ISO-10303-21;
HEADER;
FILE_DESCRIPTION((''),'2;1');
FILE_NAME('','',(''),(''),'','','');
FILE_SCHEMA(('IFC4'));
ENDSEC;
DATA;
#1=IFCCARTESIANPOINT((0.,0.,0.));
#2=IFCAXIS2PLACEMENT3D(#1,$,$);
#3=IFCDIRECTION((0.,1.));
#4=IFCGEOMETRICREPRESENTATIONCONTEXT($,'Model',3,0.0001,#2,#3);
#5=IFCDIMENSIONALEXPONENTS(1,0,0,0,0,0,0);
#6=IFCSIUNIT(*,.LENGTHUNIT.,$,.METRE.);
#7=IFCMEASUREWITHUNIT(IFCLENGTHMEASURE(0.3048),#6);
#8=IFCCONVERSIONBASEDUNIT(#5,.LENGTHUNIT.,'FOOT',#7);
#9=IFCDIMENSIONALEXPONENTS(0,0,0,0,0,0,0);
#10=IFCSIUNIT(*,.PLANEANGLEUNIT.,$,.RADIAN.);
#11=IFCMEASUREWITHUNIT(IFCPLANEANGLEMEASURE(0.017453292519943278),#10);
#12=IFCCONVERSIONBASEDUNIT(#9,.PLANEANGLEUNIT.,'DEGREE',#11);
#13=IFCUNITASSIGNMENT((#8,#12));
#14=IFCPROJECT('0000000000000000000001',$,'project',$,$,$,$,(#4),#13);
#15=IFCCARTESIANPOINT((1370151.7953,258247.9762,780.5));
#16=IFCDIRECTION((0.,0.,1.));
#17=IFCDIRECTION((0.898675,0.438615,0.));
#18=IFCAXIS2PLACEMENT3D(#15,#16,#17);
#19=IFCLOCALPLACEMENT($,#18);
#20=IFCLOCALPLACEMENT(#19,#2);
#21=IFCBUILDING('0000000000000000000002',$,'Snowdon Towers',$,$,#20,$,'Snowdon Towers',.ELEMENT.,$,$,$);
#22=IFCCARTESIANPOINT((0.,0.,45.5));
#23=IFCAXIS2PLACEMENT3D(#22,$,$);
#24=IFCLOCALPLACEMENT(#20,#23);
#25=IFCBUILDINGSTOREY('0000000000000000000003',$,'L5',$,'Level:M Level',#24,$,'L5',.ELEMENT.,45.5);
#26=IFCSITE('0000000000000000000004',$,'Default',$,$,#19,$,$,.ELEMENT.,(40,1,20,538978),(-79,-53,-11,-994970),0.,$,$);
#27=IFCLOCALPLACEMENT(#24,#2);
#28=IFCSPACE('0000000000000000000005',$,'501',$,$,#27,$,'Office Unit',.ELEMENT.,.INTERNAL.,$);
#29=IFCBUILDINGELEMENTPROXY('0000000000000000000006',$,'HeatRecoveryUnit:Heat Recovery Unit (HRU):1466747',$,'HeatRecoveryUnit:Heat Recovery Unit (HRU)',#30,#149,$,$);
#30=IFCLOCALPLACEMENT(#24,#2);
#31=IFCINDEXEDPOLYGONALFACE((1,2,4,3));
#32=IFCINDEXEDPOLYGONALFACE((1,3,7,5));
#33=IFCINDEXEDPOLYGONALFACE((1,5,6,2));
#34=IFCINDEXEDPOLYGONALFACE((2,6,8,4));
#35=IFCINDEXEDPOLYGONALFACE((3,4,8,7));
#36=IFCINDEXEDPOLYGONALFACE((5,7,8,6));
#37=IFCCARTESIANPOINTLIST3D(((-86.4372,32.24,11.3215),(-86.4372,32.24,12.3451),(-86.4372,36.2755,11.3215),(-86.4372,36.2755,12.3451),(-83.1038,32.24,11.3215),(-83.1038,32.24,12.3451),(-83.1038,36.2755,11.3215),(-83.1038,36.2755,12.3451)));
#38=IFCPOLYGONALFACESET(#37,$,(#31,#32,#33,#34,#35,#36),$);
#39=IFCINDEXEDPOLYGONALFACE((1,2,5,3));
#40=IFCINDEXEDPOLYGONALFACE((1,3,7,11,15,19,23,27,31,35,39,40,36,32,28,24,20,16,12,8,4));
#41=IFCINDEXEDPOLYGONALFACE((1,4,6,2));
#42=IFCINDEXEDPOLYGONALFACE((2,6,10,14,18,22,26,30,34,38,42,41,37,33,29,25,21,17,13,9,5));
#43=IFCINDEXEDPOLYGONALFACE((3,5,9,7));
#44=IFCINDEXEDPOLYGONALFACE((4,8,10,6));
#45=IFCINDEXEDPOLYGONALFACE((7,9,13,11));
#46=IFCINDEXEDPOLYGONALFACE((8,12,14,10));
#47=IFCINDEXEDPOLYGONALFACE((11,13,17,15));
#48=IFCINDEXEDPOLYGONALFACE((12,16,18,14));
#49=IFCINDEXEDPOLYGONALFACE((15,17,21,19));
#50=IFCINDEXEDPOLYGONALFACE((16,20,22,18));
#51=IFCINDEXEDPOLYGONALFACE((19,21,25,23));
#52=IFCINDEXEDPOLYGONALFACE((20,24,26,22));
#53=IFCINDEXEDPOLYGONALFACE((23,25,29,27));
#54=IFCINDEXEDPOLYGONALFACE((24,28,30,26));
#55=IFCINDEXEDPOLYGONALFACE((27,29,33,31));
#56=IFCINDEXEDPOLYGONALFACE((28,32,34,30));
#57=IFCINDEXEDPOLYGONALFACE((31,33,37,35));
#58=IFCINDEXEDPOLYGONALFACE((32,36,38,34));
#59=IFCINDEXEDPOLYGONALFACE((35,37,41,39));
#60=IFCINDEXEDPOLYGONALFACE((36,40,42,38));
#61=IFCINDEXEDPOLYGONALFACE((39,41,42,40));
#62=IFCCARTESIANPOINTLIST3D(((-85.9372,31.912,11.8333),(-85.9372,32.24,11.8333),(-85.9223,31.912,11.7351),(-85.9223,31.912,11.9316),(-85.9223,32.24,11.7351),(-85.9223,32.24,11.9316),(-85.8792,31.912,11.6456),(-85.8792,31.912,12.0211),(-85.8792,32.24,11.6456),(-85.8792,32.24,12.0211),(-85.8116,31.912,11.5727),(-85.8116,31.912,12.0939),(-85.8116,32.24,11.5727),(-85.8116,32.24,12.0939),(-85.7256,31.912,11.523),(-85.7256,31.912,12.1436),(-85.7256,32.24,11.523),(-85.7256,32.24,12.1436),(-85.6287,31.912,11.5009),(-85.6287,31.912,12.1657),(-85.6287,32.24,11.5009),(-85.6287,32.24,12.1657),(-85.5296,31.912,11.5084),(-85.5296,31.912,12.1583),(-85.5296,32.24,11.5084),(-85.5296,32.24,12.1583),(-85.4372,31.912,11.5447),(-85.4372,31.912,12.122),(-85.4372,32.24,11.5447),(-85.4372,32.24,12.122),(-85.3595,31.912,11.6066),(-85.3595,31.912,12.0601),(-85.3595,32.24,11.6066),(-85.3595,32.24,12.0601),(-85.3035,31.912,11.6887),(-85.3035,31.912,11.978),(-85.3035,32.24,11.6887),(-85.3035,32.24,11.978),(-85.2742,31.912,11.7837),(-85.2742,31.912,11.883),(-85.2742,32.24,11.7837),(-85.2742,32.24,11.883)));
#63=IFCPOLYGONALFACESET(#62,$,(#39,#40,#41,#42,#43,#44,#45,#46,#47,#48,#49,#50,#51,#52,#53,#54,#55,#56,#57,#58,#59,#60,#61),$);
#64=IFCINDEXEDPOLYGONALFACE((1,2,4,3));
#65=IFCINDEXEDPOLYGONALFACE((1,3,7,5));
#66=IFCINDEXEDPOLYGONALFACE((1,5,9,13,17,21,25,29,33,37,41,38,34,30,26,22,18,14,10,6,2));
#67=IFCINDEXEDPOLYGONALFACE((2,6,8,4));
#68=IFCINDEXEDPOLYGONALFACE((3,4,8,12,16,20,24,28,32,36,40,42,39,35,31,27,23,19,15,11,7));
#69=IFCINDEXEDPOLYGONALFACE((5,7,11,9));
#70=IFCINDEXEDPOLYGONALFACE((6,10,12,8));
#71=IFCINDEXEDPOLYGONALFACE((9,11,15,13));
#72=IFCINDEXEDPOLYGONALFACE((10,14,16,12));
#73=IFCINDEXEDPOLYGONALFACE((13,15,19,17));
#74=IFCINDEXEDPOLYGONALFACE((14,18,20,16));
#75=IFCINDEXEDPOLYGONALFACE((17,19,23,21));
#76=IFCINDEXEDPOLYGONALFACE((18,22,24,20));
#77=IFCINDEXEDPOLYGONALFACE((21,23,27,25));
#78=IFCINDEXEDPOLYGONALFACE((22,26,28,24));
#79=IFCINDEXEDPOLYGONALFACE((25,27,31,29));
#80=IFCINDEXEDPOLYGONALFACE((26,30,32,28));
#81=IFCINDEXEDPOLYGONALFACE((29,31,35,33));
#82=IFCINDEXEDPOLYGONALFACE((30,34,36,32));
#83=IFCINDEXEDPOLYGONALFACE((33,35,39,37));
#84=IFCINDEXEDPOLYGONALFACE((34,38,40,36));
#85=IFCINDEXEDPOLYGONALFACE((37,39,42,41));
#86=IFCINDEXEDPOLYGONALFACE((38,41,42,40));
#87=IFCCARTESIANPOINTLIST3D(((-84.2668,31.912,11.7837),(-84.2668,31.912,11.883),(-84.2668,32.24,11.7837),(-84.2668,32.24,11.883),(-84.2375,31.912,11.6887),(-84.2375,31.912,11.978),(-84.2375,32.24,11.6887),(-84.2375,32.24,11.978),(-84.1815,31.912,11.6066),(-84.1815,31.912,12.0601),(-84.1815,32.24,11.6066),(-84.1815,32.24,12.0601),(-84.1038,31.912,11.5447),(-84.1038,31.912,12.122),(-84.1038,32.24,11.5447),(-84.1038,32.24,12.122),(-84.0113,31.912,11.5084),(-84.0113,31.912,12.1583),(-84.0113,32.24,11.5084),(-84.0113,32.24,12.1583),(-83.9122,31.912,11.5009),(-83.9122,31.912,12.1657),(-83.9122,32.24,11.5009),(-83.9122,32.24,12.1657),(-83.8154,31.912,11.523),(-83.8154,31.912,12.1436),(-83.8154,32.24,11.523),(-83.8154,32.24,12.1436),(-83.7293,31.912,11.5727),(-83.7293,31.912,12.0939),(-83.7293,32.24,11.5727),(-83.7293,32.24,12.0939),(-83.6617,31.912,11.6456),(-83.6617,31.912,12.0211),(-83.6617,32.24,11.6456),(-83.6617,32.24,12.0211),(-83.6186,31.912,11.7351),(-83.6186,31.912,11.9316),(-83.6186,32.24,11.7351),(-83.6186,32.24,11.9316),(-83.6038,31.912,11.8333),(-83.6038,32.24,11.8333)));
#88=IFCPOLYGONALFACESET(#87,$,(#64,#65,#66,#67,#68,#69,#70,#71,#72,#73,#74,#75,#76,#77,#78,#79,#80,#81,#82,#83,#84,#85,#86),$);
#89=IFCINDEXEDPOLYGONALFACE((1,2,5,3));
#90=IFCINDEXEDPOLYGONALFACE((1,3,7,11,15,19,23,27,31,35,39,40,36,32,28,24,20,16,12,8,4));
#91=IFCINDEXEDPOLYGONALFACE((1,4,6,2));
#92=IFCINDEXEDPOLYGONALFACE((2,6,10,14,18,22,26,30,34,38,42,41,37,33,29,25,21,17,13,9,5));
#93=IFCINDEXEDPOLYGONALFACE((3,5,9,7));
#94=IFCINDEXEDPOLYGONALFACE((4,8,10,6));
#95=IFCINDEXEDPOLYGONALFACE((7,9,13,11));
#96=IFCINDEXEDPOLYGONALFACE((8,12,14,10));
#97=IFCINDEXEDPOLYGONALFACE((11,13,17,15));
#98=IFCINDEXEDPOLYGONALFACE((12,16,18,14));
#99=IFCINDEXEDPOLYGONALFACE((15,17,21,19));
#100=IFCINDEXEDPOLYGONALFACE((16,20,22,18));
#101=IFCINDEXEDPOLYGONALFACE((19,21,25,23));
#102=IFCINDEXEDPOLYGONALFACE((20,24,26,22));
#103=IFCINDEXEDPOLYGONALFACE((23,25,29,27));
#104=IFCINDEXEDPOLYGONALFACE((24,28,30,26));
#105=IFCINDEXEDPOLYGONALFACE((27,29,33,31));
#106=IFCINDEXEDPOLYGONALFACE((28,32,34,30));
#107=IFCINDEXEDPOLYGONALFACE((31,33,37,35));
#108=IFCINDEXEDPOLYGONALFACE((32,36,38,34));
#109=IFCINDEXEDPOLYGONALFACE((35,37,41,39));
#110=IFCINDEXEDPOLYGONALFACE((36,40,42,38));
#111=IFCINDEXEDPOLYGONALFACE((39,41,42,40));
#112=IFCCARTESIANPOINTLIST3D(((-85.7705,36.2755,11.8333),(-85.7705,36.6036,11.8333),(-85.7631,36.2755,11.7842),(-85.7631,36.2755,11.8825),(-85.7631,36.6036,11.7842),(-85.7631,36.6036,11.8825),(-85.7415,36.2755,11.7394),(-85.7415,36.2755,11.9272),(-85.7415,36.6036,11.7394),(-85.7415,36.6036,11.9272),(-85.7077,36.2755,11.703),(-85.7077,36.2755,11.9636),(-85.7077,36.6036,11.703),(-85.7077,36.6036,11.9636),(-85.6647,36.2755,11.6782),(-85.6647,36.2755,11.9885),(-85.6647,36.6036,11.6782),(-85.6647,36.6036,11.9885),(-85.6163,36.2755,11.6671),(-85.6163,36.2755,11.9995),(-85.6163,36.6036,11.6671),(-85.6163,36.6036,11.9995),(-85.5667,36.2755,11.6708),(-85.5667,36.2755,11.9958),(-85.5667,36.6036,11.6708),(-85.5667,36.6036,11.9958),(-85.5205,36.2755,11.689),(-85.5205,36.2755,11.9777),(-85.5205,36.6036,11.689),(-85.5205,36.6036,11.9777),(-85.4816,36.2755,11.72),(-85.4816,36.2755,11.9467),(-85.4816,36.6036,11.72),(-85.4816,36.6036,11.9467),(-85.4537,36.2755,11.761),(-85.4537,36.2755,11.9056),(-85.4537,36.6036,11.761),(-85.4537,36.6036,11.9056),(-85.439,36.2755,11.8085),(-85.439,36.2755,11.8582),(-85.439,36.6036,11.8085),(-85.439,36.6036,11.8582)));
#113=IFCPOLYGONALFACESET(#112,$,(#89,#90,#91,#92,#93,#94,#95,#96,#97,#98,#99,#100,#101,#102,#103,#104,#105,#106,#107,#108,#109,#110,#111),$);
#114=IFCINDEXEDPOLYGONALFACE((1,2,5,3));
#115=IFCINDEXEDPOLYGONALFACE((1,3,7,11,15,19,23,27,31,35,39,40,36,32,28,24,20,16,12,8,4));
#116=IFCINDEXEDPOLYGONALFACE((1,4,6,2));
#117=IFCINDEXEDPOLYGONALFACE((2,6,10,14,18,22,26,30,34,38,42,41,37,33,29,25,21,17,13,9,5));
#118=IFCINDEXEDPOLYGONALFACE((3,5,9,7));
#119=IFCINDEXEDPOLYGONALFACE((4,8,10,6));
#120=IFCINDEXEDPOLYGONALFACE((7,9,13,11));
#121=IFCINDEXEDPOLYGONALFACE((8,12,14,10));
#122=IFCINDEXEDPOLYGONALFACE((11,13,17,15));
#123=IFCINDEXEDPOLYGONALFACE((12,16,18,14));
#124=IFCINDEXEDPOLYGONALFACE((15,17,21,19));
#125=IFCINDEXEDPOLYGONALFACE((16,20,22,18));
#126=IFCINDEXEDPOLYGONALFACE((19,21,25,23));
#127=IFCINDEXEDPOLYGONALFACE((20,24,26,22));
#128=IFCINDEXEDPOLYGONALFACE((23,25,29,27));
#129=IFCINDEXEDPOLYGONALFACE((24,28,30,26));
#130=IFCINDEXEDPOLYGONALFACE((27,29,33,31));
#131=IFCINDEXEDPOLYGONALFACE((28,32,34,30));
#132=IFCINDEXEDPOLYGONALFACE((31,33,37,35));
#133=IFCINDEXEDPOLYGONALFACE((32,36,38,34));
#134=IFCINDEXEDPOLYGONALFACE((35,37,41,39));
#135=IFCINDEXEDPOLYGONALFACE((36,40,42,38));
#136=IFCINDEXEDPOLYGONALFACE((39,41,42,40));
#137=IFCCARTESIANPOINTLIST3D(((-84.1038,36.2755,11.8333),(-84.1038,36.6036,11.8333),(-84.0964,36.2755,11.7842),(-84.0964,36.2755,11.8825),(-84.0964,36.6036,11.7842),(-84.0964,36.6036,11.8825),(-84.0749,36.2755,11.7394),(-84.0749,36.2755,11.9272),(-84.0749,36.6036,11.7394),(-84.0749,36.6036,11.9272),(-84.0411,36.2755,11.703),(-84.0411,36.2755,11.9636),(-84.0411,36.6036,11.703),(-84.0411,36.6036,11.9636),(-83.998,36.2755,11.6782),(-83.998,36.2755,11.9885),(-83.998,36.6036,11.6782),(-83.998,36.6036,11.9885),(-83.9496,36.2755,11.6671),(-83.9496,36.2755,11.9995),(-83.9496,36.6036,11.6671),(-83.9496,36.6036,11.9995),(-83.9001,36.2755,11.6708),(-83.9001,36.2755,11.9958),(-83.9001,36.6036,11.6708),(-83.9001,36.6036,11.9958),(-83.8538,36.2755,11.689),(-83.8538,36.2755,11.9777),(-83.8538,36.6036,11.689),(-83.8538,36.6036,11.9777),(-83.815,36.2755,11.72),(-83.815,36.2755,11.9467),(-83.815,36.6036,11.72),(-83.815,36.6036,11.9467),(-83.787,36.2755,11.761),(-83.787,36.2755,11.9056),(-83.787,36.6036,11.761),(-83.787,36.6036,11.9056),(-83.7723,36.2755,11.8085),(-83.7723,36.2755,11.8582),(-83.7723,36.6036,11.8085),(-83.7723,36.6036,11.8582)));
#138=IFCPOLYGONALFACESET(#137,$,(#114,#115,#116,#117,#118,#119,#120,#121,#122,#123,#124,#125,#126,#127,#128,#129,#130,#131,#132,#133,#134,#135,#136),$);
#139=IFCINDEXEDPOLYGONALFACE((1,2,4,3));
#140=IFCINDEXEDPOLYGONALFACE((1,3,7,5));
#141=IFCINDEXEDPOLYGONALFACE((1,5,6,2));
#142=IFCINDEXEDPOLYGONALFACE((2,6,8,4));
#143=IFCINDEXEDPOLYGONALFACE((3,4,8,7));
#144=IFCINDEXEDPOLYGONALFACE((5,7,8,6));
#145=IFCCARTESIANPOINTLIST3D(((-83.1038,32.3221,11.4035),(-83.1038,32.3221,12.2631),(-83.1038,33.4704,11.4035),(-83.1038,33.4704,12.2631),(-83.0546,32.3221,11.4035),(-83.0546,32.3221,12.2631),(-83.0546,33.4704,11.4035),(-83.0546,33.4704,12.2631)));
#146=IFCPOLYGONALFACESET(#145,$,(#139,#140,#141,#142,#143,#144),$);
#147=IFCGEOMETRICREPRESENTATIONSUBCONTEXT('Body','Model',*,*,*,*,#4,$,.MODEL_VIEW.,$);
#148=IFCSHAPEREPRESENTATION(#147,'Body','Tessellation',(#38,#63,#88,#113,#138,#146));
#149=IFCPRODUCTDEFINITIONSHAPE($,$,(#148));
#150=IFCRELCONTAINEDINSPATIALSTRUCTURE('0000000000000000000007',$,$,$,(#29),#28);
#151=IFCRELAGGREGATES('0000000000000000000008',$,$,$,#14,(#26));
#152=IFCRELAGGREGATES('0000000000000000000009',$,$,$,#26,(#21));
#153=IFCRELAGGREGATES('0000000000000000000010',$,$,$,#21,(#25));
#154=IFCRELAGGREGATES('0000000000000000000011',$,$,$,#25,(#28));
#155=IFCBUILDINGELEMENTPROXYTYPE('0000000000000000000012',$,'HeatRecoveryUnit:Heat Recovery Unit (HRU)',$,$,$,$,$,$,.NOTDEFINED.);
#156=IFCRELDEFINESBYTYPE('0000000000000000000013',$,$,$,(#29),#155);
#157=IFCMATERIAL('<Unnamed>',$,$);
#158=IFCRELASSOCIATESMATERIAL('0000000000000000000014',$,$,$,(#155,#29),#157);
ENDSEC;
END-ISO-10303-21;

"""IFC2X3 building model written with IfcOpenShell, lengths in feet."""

from ifc_helpers import new_model, entity, si_unit, converted_unit, direction, frame, frame_2d, origin, origin_2d_with_axis, place, context, subcontext, project, spatial, rectangle, circle, extrude, source, transform, mapped, material, type_object, type_shapes, element, save


model = new_model("IFC2X3")

# Units and contexts
model_context = context("Model", 3, precision=0.0001, world=origin(), true_north=direction((0.0, 1.0)))
body_context = subcontext(model_context, "Body", "Model", "MODEL_VIEW")
ifc_project = project(units=[converted_unit("LENGTHUNIT", "FOOT", entity("IfcLengthMeasure", 0.3048), si_unit("LENGTHUNIT", "METRE"), dimensions=[1, 0, 0, 0, 0, 0, 0]), converted_unit("PLANEANGLEUNIT", "DEGREE", entity("IfcPlaneAngleMeasure", 0.017453292519943278), si_unit("PLANEANGLEUNIT", "RADIAN"), dimensions=[0, 0, 0, 0, 0, 0, 0])], contexts=[model_context])

# Site, building, storey
site_placement = place(None, frame((1370151.7953, 258247.9762, 780.5), z_axis=(0.0, 0.0, 1.0), x_axis=(0.898675, 0.438615, 0.0)))
site = spatial("IfcSite", under=ifc_project, at=site_placement, Name="Default", CompositionType="ELEMENT", RefLatitude=(40, 1, 20, 538978), RefLongitude=(-79, -53, -11, -994970), RefElevation=0.0)
building_placement = place(site_placement, origin())
building = spatial("IfcBuilding", under=site, at=building_placement, Name="Snowdon Towers", LongName="Snowdon Towers", CompositionType="ELEMENT")
storey_placement = place(building_placement, frame((0.0, 0.0, 45.5)))
storey = spatial("IfcBuildingStorey", under=building, at=storey_placement, Name="L5", ObjectType="Level:M Level", LongName="L5", CompositionType="ELEMENT", Elevation=45.5)

# Shared definitions
ifc_material = material(Name="<Unnamed>")

# Shared definitions
space_placement = place(storey_placement, origin())
space = spatial("IfcSpace", under=storey, at=space_placement, Name="501", LongName="Office Unit", CompositionType="ELEMENT", InteriorOrExteriorSpace="INTERNAL")

# Building element proxy
building_element_proxy_type = type_object("IfcBuildingElementProxyType", Name="HeatRecoveryUnit:Heat Recovery Unit (HRU)", PredefinedType="NOTDEFINED", material=ifc_material)
shared_shape_1 = source(origin(), body_context, "Body", "SweptSolid", [
    extrude(rectangle(XDim=3.3333, YDim=4.0354, at=origin_2d_with_axis()), frame((0.0, 0.0, 0.0), z_axis=(0.0, 0.0, 1.0), x_axis=(-1.0, 0.0, 0.0)), (0.0, 0.0, 1.0), 1.0236),
    extrude(circle(Radius=0.3333, at=frame_2d((0.0, 0.0), x_axis=(1.0, 0.0))), frame((-0.8333, -2.3458, 0.5118), z_axis=(0.0, 1.0, 0.0), x_axis=(-1.0, 0.0, 0.0)), (0.0, 0.0, 1.0), 0.3281),
    extrude(circle(Radius=0.3333, at=frame_2d((0.0, 0.0), x_axis=(1.0, 0.0))), frame((0.8333, -2.3458, 0.5118), z_axis=(0.0, 1.0, 0.0), x_axis=(1.0, 0.0, 0.0)), (0.0, 0.0, 1.0), 0.3281),
    extrude(circle(Radius=0.1667, at=frame_2d((0.0, 0.0), x_axis=(1.0, 0.0))), frame((-0.8333, 2.0177, 0.5118), z_axis=(0.0, 1.0, 0.0), x_axis=(-1.0, 0.0, 0.0)), (0.0, 0.0, 1.0), 0.3281),
    extrude(circle(Radius=0.1667, at=frame_2d((0.0, 0.0), x_axis=(1.0, 0.0))), frame((0.8333, 2.0177, 0.5118), z_axis=(0.0, 1.0, 0.0), x_axis=(-1.0, 0.0, 0.0)), (0.0, 0.0, 1.0), 0.3281),
    extrude(rectangle(XDim=0.0492, YDim=1.1483, at=origin_2d_with_axis()), frame((1.6913, -1.3615, 0.082), z_axis=(0.0, 0.0, 1.0), x_axis=(-1.0, 0.0, 0.0)), (0.0, 0.0, 1.0), 0.8596),
])
type_shapes(building_element_proxy_type, [shared_shape_1])
for number, where, name in (
    (1, (-84.7705, 34.2578, 11.3215), "HeatRecoveryUnit:Heat Recovery Unit (HRU):1466747"),
):
    element("IfcBuildingElementProxy", number, at=place(space_placement, frame(where)), inside=space, type_object=building_element_proxy_type, material=ifc_material, Name=name, ObjectType="HeatRecoveryUnit:Heat Recovery Unit (HRU)", context=body_context, shape_type="MappedRepresentation", body=[
        mapped(shared_shape_1, transform((0.0, 0.0, 0.0), scale=1.0)),
    ])

save(model, "model.ifc")
